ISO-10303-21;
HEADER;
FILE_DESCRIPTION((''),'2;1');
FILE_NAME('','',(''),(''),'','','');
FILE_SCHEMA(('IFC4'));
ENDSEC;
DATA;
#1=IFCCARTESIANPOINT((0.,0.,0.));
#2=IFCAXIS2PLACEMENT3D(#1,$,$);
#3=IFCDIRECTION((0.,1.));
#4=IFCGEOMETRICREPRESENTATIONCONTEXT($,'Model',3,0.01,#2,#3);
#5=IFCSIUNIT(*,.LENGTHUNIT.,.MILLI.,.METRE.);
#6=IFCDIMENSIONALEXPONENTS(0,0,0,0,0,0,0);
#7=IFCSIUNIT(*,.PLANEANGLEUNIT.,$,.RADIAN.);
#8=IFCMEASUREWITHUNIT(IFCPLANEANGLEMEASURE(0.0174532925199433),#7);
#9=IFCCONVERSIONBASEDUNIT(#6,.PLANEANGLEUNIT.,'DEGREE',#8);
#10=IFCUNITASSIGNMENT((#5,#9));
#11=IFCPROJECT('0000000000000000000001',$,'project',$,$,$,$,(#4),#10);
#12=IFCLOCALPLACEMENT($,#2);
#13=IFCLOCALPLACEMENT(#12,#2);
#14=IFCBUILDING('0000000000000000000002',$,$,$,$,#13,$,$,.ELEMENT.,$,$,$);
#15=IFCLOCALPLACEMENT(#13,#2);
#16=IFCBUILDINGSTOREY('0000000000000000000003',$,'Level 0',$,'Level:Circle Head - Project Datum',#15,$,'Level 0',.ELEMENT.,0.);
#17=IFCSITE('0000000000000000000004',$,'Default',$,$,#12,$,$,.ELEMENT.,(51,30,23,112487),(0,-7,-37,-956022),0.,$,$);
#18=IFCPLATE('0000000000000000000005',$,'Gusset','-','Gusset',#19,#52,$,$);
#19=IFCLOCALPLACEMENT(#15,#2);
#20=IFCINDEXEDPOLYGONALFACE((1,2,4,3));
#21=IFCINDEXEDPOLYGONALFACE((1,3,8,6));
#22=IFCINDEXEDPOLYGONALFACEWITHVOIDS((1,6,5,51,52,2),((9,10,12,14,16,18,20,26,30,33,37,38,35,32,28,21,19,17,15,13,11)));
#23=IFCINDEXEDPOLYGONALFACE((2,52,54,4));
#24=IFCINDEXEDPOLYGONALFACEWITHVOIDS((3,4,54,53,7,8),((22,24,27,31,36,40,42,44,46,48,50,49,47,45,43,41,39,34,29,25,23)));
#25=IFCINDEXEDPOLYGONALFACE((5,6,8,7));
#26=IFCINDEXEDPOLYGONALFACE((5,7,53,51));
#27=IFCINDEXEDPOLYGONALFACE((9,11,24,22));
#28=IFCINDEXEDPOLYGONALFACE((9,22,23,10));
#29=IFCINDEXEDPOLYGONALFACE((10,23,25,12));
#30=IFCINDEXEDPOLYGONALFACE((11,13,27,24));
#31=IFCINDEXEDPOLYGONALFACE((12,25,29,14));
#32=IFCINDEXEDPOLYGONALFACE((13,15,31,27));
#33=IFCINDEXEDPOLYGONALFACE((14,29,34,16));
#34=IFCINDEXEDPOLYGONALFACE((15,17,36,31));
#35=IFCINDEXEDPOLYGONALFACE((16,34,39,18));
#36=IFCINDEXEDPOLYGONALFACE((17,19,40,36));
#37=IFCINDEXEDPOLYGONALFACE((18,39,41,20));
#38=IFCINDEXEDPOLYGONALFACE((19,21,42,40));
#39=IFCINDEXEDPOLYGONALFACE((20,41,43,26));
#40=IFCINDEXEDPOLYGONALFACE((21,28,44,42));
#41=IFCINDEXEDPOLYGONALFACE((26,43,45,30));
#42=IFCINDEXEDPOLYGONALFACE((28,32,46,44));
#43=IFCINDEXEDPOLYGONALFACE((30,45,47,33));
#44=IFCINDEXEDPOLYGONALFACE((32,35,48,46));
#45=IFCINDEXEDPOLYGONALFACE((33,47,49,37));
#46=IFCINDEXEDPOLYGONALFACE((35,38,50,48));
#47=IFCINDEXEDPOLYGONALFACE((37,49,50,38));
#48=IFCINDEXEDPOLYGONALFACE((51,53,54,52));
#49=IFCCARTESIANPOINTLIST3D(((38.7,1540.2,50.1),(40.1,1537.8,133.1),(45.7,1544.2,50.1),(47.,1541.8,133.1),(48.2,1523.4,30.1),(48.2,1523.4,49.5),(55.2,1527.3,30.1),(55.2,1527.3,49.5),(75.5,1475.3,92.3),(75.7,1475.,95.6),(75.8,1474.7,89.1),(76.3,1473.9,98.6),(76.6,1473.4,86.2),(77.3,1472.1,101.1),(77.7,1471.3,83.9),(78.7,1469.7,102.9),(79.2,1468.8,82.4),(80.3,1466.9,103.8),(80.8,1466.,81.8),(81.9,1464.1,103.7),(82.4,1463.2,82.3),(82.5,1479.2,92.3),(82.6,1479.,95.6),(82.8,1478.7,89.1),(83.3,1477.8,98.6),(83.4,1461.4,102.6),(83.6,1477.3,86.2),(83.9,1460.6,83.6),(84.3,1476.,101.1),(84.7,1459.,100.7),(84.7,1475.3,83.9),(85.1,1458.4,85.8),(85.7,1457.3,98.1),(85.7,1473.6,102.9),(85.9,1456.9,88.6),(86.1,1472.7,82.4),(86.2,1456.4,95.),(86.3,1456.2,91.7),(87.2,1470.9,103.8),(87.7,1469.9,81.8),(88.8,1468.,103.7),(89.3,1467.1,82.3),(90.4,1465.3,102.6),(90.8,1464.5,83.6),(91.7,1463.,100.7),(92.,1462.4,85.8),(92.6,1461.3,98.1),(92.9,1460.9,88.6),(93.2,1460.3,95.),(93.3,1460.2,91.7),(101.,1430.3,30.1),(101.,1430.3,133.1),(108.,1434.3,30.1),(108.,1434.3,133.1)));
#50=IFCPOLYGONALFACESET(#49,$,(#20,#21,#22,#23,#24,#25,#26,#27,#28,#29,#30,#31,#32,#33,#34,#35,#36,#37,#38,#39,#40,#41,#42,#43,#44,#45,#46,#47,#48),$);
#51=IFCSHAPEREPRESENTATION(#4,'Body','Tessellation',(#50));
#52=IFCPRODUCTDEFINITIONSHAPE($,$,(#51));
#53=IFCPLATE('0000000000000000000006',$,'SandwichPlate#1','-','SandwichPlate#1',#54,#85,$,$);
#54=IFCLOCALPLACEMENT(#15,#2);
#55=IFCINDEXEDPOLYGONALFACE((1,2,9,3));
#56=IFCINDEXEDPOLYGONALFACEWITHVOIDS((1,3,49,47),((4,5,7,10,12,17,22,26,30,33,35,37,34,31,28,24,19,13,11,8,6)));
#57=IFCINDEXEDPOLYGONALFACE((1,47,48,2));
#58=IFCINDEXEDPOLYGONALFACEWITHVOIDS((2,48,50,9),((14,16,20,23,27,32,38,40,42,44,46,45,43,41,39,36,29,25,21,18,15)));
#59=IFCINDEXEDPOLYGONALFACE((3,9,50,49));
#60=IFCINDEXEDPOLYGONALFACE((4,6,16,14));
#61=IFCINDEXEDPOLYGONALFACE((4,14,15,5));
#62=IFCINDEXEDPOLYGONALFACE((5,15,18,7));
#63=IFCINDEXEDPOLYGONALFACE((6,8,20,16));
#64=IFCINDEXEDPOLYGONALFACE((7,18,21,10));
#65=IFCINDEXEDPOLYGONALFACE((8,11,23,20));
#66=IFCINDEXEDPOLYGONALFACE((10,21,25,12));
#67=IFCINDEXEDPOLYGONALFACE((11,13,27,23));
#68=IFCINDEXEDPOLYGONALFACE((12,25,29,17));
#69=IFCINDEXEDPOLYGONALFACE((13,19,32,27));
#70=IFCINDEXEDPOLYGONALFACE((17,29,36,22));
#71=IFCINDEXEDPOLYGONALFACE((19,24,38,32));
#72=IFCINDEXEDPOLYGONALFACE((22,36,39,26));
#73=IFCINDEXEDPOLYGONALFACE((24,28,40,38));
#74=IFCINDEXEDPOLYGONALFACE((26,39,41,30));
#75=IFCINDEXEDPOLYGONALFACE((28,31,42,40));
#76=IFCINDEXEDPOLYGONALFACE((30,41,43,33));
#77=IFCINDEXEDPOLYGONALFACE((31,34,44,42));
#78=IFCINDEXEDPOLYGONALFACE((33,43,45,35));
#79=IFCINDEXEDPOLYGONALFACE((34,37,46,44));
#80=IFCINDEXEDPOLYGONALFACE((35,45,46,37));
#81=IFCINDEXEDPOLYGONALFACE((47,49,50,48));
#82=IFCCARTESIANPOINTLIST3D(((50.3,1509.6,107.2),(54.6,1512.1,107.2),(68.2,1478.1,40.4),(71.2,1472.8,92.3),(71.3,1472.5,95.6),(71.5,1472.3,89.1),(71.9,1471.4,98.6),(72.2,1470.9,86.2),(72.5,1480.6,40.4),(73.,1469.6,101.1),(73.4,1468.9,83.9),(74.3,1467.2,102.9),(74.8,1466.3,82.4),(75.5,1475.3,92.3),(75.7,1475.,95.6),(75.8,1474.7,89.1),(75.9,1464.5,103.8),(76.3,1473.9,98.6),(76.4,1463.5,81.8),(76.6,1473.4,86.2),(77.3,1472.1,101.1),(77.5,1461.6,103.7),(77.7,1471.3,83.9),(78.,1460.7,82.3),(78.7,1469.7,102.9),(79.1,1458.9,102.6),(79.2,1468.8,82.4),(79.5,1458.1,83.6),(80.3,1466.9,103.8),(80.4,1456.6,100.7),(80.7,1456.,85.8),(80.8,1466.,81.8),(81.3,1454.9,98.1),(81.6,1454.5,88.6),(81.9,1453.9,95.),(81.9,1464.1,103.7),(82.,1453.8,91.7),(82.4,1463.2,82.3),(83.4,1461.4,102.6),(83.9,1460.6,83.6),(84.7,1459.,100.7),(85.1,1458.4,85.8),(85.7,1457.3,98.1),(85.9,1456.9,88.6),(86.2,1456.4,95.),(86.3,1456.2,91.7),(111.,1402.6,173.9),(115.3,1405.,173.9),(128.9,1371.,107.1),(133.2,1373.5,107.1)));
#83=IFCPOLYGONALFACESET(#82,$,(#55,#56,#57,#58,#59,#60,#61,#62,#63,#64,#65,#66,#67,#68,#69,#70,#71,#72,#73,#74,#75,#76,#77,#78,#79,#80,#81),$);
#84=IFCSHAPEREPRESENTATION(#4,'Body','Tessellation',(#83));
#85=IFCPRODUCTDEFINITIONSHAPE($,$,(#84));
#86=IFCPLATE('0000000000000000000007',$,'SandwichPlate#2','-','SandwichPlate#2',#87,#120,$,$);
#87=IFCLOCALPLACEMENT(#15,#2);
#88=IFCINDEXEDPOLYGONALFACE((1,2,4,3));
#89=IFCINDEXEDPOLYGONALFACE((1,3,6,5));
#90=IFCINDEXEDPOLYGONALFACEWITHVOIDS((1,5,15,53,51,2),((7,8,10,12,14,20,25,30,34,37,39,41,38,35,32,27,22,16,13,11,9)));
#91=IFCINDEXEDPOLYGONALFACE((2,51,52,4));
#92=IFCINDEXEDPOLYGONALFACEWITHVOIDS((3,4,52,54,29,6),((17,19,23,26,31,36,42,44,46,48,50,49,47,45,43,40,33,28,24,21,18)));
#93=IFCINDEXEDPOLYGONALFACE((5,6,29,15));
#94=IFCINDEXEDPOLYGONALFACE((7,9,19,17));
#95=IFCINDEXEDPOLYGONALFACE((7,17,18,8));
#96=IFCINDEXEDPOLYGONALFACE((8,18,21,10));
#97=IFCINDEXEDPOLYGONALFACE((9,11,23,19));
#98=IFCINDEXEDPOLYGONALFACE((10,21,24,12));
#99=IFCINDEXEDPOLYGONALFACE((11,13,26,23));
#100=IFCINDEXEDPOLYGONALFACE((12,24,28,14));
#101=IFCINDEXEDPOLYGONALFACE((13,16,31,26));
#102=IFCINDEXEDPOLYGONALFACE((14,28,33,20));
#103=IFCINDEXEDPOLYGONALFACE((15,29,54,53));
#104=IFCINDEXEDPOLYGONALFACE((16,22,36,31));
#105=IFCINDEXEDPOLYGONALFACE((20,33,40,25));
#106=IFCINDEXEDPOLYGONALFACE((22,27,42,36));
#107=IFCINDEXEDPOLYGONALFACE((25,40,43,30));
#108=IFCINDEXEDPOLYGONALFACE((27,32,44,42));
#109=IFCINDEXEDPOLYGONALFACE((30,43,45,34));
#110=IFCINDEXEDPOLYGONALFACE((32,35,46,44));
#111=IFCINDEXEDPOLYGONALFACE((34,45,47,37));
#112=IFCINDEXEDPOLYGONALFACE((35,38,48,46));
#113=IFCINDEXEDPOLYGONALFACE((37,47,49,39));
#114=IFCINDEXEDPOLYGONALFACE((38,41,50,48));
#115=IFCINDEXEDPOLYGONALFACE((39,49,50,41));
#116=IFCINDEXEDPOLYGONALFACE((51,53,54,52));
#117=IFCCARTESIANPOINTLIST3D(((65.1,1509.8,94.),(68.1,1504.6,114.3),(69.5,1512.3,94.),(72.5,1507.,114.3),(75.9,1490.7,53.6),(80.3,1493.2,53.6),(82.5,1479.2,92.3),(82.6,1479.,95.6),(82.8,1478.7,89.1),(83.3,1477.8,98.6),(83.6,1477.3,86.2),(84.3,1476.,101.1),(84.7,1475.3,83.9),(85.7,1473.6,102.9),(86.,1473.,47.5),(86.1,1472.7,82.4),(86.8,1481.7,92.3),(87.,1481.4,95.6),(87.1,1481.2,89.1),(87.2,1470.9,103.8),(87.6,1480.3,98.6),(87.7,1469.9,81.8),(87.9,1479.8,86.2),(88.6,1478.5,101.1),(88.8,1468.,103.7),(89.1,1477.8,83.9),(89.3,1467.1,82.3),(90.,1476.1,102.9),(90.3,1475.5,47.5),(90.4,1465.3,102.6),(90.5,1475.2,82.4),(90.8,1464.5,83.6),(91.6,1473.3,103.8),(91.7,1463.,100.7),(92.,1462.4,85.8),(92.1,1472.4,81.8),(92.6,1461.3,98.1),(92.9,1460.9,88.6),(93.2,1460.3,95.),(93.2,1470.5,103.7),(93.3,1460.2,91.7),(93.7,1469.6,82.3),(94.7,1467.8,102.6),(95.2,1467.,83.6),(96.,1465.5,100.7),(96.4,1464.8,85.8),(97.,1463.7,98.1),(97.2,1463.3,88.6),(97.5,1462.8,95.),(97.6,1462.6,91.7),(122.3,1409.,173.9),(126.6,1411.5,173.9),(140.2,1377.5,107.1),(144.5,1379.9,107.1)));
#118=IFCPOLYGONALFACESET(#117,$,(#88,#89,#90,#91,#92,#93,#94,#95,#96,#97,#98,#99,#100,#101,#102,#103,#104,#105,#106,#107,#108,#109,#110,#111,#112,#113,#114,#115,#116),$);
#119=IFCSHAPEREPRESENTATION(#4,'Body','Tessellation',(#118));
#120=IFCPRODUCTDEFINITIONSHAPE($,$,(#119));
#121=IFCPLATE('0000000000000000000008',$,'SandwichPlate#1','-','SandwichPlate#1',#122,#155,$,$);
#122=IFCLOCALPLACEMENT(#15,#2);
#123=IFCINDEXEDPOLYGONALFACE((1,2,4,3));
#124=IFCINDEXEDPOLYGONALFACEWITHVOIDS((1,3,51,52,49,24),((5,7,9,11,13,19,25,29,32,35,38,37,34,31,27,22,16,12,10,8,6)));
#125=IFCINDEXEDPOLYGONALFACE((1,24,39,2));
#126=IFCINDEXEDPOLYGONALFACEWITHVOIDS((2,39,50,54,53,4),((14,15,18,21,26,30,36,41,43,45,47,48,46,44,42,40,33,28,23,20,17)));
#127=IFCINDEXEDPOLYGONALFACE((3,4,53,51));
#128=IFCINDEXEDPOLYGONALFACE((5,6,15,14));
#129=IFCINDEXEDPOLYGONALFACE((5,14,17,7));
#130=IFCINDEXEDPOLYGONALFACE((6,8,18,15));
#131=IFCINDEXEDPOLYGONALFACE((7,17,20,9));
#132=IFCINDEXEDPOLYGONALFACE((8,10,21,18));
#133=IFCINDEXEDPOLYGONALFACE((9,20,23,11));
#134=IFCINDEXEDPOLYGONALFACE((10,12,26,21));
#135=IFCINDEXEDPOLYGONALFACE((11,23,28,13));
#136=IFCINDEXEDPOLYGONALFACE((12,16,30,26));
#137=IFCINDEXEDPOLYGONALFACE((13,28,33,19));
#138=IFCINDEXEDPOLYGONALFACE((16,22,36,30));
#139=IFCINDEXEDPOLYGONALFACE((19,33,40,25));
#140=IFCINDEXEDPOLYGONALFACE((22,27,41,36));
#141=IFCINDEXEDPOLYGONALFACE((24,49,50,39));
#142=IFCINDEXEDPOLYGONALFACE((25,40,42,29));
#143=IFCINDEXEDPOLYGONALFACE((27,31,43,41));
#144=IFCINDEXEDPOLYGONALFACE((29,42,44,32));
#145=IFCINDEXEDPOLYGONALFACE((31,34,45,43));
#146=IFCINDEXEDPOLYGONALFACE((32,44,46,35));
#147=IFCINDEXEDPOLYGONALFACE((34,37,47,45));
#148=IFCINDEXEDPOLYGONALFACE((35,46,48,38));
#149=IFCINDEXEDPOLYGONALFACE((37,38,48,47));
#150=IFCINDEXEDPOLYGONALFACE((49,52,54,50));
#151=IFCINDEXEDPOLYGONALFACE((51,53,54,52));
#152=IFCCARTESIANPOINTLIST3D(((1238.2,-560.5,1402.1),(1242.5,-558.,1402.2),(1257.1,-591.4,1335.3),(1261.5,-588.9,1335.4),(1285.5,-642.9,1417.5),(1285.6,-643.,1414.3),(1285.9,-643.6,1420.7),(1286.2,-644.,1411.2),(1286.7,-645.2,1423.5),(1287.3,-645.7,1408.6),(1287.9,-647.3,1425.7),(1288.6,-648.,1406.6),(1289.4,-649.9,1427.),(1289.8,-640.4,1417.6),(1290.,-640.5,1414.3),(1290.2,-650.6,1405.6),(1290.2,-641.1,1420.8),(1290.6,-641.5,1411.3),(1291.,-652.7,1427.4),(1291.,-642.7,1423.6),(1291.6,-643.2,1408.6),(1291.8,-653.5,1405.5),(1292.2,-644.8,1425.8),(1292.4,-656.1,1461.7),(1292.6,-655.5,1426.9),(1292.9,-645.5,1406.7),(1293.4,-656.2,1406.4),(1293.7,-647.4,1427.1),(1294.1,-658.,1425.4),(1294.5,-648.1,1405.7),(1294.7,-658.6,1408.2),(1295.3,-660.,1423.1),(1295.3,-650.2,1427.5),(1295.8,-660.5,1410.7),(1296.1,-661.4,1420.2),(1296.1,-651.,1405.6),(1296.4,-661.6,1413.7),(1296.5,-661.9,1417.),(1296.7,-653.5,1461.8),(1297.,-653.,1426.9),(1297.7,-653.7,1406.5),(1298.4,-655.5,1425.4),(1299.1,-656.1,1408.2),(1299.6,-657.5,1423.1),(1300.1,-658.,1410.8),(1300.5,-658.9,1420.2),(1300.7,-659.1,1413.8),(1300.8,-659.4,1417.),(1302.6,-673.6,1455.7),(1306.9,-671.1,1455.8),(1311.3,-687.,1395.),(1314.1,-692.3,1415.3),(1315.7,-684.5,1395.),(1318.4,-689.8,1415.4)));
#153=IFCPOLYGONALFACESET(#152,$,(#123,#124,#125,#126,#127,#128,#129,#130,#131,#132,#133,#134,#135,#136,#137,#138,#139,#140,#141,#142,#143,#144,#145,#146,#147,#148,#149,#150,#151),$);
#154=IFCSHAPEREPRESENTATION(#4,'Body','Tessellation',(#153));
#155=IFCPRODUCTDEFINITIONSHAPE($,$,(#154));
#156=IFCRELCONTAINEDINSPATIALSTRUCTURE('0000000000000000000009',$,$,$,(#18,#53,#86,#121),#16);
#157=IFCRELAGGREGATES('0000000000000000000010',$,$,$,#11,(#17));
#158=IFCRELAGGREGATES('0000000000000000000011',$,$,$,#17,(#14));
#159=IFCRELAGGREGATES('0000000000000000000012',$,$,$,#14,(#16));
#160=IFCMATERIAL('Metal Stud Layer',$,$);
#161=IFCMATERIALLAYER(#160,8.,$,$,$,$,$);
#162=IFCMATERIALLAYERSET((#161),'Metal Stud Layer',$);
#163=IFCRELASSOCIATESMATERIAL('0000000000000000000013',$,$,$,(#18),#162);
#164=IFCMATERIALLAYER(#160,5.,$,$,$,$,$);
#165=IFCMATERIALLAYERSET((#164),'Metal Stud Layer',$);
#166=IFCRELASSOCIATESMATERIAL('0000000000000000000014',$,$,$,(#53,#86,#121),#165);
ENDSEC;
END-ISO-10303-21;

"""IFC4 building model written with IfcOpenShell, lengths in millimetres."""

from ifc_helpers import new_model, entity, si_unit, converted_unit, point, direction, frame, frame_2d, origin, origin_with_axes, origin_2d_with_axis, place, context, project, spatial, polyline, circle_curve, line_curve, trimmed, segment, composite_curve, circle, outline, extrude, material, layer, layer_set, element, save


model = new_model("IFC4")

# Units and contexts
model_context = context("Model", 3, precision=0.01, world=origin(), true_north=direction((0.0, 1.0)))
ifc_project = project(units=[si_unit("LENGTHUNIT", "METRE", prefix="MILLI"), converted_unit("PLANEANGLEUNIT", "DEGREE", entity("IfcPlaneAngleMeasure", 0.0174532925199433), si_unit("PLANEANGLEUNIT", "RADIAN"), dimensions=[0, 0, 0, 0, 0, 0, 0])], contexts=[model_context])

# Site, building, storey
site_placement = place(None, origin())
site = spatial("IfcSite", under=ifc_project, at=site_placement, Name="Default", CompositionType="ELEMENT", RefLatitude=(51, 30, 23, 112487), RefLongitude=(0, -7, -37, -956022), RefElevation=0.0)
building_placement = place(site_placement, origin())
building = spatial("IfcBuilding", under=site, at=building_placement, CompositionType="ELEMENT")
storey_placement = place(building_placement, origin())
storey = spatial("IfcBuildingStorey", under=building, at=storey_placement, Name="Level 0", ObjectType="Level:Circle Head - Project Datum", LongName="Level 0", CompositionType="ELEMENT", Elevation=0.0)

# Shared definitions
ifc_material_1 = material(Name="Metal Stud Layer")
ifc_layer_1 = layer(ifc_material_1, 8.0)
ifc_layer_set_1 = layer_set([ifc_layer_1], Name="Metal Stud Layer")

# Shared definitions
ifc_layer_2 = layer(ifc_material_1, 5.0)
ifc_layer_set_2 = layer_set([ifc_layer_2], Name="Metal Stud Layer")

# Plate, openings
plate_1_placement = place(storey_placement, frame((41.3, 1535.6, 143.5), z_axis=(0.869914, 0.493203, 0.0), x_axis=(0.492931, -0.869436, -0.033166)))
plate_1 = element("IfcPlate", 1, at=plate_1_placement, inside=storey, material=ifc_layer_set_1, Name="Gusset", Description="-", ObjectType="Gusset", context=model_context, shape_type="SweptSolid", body=[
    extrude(outline(polyline([(17.1, 93.5), (-2.2, 93.5), (-2.2, 10.5), (121.3, 6.4), (124.7, 109.3), (17.8, 112.9), (17.1, 93.5)])), origin_with_axes(), (0.0, 0.0, 1.0), 8.0),
])
opening_1_placement = place(plate_1_placement, origin_with_axes())
element("IfcOpeningElement", 2, at=opening_1_placement, cuts=plate_1, ObjectType="Opening", context=model_context, shape_type="SweptSolid", body=[
    extrude(outline(composite_curve([segment(trimmed(line_curve((17.1, 93.5), (-1.0, 0.0), 19.347323), [point((17.1, 93.5))], [point((-2.2, 93.5))], True, "CARTESIAN"), True, "CONTINUOUS"), segment(trimmed(circle_curve(frame_2d((-2.2, 113.5), x_axis=(1.0, 0.0)), 20.0), [point((-2.2, 93.5))], [point((17.8, 112.9))], True, "CARTESIAN"), True, "CONTINUOUS"), segment(trimmed(line_curve((17.8, 112.9), (-0.033166, -0.99945), 19.347323), [point((17.8, 112.9))], [point((17.1, 93.5))], True, "CARTESIAN"), True, "CONTINUOUS")], self_intersect="UNKNOWN")), origin(), (0.0, 0.0, 1.0), 8.0),
])
opening_2_placement = place(plate_1_placement, frame((81.9, 48.0, 8.5), z_axis=(0.0, 0.0, -1.0), x_axis=(0.862665, -0.505775, 0.0)))
element("IfcOpeningElement", 3, at=opening_2_placement, cuts=plate_1, ObjectType="Opening", context=model_context, shape_type="SweptSolid", body=[
    extrude(circle(Radius=11.0, at=origin_2d_with_axis()), origin(), (0.0, 0.0, 1.0), 9.0),
])

# Plates, openings
plate_2_placement = place(storey_placement, frame((54.6, 1512.1, 107.2), z_axis=(-0.869914, -0.493203, 0.0), x_axis=(0.235201, -0.41485, -0.878965)))
plate_2 = element("IfcPlate", 4, at=plate_2_placement, inside=storey, material=ifc_layer_set_2, Name="SandwichPlate#1", Description="-", ObjectType="SandwichPlate#1", context=model_context, shape_type="SweptSolid", body=[
    extrude(outline(polyline([(0.0, 0.0), (76.0, 0.0), (76.0, 140.0), (0.0, 140.0), (0.0, 0.0)])), origin_with_axes(), (0.0, 0.0, 1.0), 5.0),
])
opening_3_placement = place(plate_2_placement, frame((38.0, 40.0, -0.5), z_axis=(0.0, 0.0, 1.0), x_axis=(0.0, 1.0, 0.0)))
element("IfcOpeningElement", 5, at=opening_3_placement, cuts=plate_2, ObjectType="Opening", context=model_context, shape_type="SweptSolid", body=[
    extrude(circle(Radius=11.0, at=origin_2d_with_axis()), origin(), (0.0, 0.0, 1.0), 6.0),
])
plate_3_placement = place(storey_placement, frame((66.0, 1518.5, 107.2), z_axis=(-0.869914, -0.493203, 0.0), x_axis=(0.235201, -0.41485, -0.878965)))
plate_3 = element("IfcPlate", 6, at=plate_3_placement, inside=storey, material=ifc_layer_set_2, Name="SandwichPlate#2", Description="-", ObjectType="SandwichPlate#2", context=model_context, shape_type="SweptSolid", body=[
    extrude(outline(polyline([(15.0, 0.0), (61.0, 0.0), (76.0, 15.0), (76.0, 140.0), (0.0, 140.0), (0.0, 15.0), (15.0, 0.0)])), origin_with_axes(), (0.0, 0.0, 1.0), 5.0),
])
opening_4_placement = place(plate_3_placement, frame((38.0, 40.0, -0.5), z_axis=(0.0, 0.0, 1.0), x_axis=(0.0, 1.0, 0.0)))
element("IfcOpeningElement", 7, at=opening_4_placement, cuts=plate_3, ObjectType="Opening", context=model_context, shape_type="SweptSolid", body=[
    extrude(circle(Radius=11.0, at=origin_2d_with_axis()), origin(), (0.0, 0.0, 1.0), 6.0),
])

# Plate, openings
plate_4_placement = place(storey_placement, frame((1322.2, -695.9, 1402.2), z_axis=(-0.865935, -0.499948, -0.014432), x_axis=(-0.249453, 0.406695, 0.878847)))
plate_4 = element("IfcPlate", 8, at=plate_4_placement, inside=storey, material=ifc_layer_set_2, Name="SandwichPlate#1", Description="-", ObjectType="SandwichPlate#1", context=model_context, shape_type="SweptSolid", body=[
    extrude(outline(polyline([(0.0, 0.0), (76.0, 0.0), (76.0, 140.0), (0.0, 140.0), (0.0, 0.0)])), origin_with_axes(), (0.0, 0.0, 1.0), 5.0),
])
opening_5_placement = place(plate_4_placement, frame((0.0, 0.0, 0.0), z_axis=(0.0, 0.0, 1.0), x_axis=(1.0, 0.0, 0.0)))
element("IfcOpeningElement", 9, at=opening_5_placement, cuts=plate_4, ObjectType="Opening", context=model_context, shape_type="SweptSolid", body=[
    extrude(outline(polyline([(0.0, 0.0), (15.0, 0.0), (0.0, 15.0), (0.0, 0.0)])), origin(), (0.0, 0.0, 1.0), 5.0),
])
opening_6_placement = place(plate_4_placement, frame((0.0, 0.0, 0.0), z_axis=(0.0, 0.0, 1.0), x_axis=(1.0, 0.0, 0.0)))
element("IfcOpeningElement", 10, at=opening_6_placement, cuts=plate_4, ObjectType="Opening", context=model_context, shape_type="SweptSolid", body=[
    extrude(outline(polyline([(76.0, 0.0), (76.0, 15.0), (61.0, 0.0), (76.0, 0.0)])), origin(), (0.0, 0.0, 1.0), 5.0),
])
opening_7_placement = place(plate_4_placement, frame((38.0, 40.0, -0.5), z_axis=(0.0, 0.0, 1.0), x_axis=(0.0, 1.0, 0.0)))
element("IfcOpeningElement", 11, at=opening_7_placement, cuts=plate_4, ObjectType="Opening", context=model_context, shape_type="SweptSolid", body=[
    extrude(circle(Radius=11.0, at=origin_2d_with_axis()), origin(), (0.0, 0.0, 1.0), 6.0),
])

save(model, "model.ifc")
